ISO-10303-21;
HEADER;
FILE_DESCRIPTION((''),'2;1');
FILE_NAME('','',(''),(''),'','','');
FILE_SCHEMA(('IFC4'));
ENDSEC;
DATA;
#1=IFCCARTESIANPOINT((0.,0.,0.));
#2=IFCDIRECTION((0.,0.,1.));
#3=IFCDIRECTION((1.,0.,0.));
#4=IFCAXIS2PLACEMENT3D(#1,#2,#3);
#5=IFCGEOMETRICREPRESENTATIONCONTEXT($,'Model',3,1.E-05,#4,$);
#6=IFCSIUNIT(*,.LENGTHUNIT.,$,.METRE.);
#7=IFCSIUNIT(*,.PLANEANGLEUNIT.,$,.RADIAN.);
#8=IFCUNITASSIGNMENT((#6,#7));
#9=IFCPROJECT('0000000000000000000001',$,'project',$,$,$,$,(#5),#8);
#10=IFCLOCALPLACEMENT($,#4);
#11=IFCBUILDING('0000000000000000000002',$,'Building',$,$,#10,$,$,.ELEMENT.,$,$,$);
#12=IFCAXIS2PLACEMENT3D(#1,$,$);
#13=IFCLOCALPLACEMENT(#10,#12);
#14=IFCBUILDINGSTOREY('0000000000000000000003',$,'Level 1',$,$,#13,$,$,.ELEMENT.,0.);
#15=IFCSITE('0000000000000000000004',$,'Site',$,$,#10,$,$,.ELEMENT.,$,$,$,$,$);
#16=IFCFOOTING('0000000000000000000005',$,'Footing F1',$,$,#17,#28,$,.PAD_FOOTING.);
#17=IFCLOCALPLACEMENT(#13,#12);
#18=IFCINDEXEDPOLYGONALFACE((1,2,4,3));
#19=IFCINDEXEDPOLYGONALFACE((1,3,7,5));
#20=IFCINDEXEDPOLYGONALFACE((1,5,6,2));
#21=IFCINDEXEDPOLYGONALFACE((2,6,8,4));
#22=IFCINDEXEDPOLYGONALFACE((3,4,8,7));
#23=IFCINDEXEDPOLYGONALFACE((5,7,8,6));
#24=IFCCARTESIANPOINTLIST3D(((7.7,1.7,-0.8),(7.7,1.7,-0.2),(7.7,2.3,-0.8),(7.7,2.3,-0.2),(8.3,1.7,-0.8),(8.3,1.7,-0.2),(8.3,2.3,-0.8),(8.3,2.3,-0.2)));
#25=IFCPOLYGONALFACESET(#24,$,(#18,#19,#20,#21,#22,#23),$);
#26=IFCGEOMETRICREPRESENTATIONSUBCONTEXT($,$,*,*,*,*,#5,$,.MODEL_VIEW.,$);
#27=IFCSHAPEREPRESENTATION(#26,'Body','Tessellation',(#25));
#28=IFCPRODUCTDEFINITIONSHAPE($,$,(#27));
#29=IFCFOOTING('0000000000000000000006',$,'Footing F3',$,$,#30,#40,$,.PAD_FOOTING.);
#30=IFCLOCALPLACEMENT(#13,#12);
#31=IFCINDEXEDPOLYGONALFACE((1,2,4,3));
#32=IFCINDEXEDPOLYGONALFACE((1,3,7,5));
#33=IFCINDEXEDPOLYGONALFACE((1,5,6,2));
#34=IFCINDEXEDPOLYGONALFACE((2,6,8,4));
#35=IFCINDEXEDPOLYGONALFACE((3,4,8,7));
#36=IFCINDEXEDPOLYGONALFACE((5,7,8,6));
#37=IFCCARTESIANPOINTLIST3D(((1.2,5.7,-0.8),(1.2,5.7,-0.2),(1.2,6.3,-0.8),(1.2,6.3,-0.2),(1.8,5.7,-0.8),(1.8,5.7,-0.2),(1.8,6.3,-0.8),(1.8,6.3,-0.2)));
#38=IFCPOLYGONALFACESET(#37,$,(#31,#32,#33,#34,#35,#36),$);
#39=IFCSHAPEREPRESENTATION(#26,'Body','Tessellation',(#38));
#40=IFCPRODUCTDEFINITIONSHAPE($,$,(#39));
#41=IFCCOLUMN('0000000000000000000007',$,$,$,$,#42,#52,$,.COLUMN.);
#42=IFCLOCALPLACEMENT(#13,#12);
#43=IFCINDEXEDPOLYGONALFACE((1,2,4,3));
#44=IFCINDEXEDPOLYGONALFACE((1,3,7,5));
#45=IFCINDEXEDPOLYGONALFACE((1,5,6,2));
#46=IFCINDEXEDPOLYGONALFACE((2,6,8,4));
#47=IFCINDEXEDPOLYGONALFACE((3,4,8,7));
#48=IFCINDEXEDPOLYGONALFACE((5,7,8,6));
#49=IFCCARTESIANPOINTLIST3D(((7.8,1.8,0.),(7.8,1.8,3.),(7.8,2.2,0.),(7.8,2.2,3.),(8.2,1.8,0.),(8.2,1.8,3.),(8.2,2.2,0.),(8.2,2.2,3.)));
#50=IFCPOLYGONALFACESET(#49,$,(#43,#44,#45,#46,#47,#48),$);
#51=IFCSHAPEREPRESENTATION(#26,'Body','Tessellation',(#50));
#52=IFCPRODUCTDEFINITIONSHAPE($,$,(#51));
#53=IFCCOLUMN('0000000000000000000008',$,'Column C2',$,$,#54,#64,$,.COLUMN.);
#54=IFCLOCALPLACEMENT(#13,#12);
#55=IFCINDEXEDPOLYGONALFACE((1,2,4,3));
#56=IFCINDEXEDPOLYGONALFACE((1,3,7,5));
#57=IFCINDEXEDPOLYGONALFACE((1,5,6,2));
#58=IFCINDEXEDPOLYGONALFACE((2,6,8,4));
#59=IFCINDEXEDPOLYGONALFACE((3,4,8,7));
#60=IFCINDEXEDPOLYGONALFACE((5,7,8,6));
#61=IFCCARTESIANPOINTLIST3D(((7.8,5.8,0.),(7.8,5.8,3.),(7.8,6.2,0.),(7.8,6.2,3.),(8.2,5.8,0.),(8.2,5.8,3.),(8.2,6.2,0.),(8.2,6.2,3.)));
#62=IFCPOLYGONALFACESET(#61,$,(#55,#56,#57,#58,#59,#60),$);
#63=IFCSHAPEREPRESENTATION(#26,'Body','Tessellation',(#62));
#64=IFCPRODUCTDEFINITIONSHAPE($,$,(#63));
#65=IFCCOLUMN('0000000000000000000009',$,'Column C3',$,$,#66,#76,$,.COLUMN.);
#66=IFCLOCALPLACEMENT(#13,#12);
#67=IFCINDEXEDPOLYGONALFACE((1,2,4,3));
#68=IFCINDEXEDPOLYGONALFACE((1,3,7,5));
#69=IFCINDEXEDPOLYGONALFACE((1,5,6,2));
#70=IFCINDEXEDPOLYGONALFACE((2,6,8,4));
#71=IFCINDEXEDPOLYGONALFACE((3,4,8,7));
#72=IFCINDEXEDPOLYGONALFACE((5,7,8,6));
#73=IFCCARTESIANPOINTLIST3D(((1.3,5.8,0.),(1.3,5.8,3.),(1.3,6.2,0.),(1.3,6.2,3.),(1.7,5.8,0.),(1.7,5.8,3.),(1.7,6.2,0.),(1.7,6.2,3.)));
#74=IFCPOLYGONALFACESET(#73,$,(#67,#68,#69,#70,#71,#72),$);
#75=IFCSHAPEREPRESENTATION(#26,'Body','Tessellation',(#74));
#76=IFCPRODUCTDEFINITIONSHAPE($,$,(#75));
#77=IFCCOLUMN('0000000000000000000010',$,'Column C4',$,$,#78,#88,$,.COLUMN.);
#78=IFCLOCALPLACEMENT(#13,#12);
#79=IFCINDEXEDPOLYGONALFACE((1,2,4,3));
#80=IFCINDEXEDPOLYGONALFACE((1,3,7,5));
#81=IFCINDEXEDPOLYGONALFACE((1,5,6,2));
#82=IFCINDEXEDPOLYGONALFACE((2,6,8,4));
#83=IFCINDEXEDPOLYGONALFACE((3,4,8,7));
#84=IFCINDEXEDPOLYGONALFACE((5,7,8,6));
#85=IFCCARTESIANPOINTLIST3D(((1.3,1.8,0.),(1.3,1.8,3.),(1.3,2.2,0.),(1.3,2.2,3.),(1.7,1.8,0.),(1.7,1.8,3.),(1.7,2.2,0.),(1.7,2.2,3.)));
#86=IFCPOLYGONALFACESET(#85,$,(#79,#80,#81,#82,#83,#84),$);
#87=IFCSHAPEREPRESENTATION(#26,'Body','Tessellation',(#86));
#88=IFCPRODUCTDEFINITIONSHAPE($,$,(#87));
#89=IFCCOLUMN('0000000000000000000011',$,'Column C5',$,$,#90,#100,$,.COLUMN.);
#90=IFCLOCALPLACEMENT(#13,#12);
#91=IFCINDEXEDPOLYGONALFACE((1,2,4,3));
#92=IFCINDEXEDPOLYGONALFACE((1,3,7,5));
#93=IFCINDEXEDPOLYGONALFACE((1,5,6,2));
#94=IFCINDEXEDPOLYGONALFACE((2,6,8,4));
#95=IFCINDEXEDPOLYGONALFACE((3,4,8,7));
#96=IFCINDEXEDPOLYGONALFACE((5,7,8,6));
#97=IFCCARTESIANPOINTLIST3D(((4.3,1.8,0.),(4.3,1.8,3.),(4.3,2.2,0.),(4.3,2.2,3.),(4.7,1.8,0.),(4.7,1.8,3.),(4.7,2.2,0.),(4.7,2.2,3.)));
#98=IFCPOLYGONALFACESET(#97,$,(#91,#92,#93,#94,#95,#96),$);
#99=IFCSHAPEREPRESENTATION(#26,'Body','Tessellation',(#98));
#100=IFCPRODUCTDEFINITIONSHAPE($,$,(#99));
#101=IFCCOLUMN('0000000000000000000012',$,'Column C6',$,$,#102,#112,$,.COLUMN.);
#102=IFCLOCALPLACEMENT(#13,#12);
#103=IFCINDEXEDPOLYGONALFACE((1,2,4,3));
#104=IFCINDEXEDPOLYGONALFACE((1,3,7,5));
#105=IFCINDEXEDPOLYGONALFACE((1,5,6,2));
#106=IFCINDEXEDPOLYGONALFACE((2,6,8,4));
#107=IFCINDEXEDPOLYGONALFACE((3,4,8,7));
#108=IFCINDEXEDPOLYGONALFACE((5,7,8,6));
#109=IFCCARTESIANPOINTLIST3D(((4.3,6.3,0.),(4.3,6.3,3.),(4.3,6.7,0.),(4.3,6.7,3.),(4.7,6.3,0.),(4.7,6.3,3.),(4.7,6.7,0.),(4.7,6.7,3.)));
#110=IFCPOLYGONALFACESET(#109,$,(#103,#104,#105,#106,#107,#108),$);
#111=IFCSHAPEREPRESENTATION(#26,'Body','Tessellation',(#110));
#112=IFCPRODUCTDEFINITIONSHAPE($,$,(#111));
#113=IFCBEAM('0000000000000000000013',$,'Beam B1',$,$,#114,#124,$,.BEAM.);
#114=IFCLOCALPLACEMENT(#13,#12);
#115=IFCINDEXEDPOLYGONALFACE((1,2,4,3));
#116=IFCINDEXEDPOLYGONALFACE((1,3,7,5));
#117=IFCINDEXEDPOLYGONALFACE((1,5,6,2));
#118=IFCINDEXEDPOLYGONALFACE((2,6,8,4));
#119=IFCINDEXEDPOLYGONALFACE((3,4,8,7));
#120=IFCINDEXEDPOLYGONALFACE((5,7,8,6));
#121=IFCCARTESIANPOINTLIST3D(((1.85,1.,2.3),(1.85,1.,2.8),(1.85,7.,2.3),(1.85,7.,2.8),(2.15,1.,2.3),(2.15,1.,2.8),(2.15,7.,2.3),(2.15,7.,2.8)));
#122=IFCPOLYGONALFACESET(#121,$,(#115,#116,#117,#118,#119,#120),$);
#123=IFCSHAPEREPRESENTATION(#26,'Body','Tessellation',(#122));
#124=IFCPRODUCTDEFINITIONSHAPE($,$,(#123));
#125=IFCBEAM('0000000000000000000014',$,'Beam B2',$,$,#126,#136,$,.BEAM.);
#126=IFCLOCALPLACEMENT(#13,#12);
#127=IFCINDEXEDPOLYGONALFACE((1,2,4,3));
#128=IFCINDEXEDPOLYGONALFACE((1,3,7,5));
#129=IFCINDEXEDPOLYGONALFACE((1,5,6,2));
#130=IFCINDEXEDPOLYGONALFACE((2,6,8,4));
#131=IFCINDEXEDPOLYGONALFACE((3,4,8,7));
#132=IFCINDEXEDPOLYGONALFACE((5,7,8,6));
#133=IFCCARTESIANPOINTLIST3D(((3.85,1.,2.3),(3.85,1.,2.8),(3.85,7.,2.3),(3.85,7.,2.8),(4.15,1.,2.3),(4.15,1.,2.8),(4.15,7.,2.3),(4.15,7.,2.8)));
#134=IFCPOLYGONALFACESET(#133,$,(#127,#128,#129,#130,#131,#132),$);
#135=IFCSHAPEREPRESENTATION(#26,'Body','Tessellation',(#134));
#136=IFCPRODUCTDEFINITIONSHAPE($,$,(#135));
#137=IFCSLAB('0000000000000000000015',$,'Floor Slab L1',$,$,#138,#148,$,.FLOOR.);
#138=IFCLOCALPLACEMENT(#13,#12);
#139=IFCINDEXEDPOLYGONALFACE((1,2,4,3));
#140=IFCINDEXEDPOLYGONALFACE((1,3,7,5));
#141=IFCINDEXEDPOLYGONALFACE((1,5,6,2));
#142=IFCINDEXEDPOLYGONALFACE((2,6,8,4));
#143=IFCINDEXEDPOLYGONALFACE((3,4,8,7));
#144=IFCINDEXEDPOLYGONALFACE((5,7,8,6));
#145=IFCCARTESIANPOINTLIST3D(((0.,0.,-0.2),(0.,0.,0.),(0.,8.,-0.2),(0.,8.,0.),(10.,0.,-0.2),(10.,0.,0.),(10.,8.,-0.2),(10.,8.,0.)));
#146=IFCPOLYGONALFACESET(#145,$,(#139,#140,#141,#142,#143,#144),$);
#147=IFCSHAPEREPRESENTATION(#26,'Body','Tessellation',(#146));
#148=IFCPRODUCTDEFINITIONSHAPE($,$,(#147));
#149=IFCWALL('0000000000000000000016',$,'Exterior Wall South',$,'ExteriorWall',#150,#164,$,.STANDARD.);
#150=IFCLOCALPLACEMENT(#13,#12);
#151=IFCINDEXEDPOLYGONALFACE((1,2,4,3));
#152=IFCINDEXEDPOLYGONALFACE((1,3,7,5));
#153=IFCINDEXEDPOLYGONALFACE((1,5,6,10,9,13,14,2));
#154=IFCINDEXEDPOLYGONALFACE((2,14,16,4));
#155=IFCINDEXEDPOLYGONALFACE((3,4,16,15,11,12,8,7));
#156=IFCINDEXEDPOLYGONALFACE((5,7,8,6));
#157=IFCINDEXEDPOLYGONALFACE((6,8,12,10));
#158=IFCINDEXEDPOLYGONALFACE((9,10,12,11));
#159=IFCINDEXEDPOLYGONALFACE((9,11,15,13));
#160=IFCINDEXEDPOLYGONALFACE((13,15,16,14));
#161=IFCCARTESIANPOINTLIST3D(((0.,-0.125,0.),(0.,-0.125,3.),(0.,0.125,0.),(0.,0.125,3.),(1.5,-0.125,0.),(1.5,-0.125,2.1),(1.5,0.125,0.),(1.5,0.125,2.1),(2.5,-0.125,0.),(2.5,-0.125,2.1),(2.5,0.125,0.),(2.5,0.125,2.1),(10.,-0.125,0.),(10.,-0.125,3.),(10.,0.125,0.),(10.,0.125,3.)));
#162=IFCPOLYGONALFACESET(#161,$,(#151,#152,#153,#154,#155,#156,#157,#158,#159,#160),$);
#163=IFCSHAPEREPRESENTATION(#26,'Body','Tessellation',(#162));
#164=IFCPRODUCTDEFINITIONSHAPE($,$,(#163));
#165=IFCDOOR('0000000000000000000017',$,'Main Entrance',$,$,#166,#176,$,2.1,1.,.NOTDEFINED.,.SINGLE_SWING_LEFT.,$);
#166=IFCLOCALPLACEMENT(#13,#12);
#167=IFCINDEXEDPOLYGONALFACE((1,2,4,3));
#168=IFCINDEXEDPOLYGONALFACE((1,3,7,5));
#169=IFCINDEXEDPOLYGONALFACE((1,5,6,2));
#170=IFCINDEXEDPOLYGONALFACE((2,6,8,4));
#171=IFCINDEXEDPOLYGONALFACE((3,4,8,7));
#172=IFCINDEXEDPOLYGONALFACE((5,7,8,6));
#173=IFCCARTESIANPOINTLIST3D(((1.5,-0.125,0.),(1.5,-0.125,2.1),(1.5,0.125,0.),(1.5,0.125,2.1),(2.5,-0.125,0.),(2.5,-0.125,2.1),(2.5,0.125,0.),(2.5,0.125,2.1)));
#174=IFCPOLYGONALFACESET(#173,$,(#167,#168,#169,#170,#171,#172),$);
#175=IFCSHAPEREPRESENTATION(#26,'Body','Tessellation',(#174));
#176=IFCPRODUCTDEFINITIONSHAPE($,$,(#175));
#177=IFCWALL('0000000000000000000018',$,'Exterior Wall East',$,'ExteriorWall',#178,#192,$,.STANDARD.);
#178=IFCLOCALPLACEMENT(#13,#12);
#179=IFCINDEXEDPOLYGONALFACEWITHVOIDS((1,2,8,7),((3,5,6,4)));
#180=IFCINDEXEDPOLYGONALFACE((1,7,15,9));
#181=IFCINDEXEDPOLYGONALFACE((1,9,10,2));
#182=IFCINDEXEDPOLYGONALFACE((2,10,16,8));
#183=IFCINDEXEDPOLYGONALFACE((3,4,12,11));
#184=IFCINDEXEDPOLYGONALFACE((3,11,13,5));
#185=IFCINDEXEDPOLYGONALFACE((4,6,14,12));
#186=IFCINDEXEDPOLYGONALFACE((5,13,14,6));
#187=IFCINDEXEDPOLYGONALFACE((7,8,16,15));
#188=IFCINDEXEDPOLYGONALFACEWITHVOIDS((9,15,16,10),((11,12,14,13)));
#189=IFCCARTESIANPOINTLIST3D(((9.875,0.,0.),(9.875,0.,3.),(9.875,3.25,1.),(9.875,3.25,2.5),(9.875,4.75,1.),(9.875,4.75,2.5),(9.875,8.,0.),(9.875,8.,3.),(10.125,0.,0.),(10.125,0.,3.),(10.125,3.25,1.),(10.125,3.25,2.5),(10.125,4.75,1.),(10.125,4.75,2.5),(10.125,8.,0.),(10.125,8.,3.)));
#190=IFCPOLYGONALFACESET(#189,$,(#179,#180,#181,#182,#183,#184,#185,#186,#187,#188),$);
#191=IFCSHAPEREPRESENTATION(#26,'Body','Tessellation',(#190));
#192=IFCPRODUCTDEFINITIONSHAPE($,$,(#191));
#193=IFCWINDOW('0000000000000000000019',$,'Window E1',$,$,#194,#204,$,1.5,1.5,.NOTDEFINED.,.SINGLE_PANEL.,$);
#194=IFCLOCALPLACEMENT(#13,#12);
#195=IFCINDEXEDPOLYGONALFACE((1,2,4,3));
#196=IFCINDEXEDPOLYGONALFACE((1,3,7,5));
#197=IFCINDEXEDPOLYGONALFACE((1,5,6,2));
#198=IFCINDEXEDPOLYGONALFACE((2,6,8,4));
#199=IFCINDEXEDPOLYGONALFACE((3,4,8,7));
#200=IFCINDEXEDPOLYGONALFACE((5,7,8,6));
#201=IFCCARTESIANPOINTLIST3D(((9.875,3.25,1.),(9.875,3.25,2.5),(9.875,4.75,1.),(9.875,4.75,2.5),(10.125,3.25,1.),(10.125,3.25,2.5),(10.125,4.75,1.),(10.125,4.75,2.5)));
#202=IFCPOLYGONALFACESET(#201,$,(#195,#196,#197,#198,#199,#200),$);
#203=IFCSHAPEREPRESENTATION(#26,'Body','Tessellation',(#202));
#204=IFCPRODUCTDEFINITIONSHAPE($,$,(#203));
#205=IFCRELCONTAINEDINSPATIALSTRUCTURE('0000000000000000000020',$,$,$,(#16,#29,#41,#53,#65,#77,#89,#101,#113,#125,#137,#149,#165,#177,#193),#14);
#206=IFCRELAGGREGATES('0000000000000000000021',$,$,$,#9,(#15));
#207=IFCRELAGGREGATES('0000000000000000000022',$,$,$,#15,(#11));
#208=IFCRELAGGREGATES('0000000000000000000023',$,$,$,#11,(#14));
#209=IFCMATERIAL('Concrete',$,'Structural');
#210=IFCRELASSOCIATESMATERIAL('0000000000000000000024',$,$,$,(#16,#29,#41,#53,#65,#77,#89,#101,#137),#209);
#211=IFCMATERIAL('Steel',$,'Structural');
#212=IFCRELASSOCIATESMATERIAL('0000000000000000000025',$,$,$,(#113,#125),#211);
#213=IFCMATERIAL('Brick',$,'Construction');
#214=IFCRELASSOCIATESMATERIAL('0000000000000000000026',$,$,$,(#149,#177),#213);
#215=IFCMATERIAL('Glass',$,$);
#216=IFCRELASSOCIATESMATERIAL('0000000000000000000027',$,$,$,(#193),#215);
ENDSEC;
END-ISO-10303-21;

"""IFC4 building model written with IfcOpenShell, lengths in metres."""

from ifc_helpers import new_model, si_unit, frame, frame_2d, origin, origin_with_axes, origin_2d, place, context, subcontext, project, spatial, rectangle, extrude, material, element, fill, save


model = new_model("IFC4")

# Units and contexts
model_context = context("Model", 3, precision=1e-05, world=origin_with_axes())
sub_context = subcontext(model_context, None, None, "MODEL_VIEW")
ifc_project = project(units=[si_unit("LENGTHUNIT", "METRE"), si_unit("PLANEANGLEUNIT", "RADIAN")], contexts=[model_context])

# Site, building, storey
placement = place(None, origin_with_axes())
site = spatial("IfcSite", under=ifc_project, at=placement, Name="Site", CompositionType="ELEMENT")
building = spatial("IfcBuilding", under=site, at=placement, Name="Building", CompositionType="ELEMENT")
storey_placement = place(placement, origin())
storey = spatial("IfcBuildingStorey", under=building, at=storey_placement, Name="Level 1", CompositionType="ELEMENT", Elevation=0.0)

# Footings
ifc_material_1 = material(Name="Concrete", Category="Structural")
for number, where, name in (
    (1, (8.0, 2.0, -0.8), "Footing F1"),
    (2, (1.5, 6.0, -0.8), "Footing F3"),
):
    element("IfcFooting", number, at=place(placement, frame(where)), inside=storey, material=ifc_material_1, Name=name, PredefinedType="PAD_FOOTING", context=sub_context, shape_type="SweptSolid", body=[
        extrude(rectangle(XDim=0.6, YDim=0.6, at=origin_2d()), origin(), (0.0, 0.0, 1.0), 0.6),
    ])

# Columns
column_placement = place(storey_placement, frame((8.0, 2.0, 0.0)))
element("IfcColumn", 3, at=column_placement, inside=storey, material=ifc_material_1, PredefinedType="COLUMN", context=sub_context, shape_type="SweptSolid", body=[
    extrude(rectangle(XDim=0.4, YDim=0.4, at=origin_2d()), origin(), (0.0, 0.0, 1.0), 3.0),
])
for number, where, name in (
    (4, (8.0, 6.0, 0.0), "Column C2"),
    (5, (1.5, 6.0, 0.0), "Column C3"),
    (6, (1.5, 2.0, 0.0), "Column C4"),
    (7, (4.5, 2.0, 0.0), "Column C5"),
    (8, (4.5, 6.5, 0.0), "Column C6"),
):
    element("IfcColumn", number, at=place(storey_placement, frame(where)), inside=storey, material=ifc_material_1, Name=name, PredefinedType="COLUMN", context=sub_context, shape_type="SweptSolid", body=[
        extrude(rectangle(XDim=0.4, YDim=0.4, at=origin_2d()), origin(), (0.0, 0.0, 1.0), 3.0),
    ])

# Beams
ifc_material_2 = material(Name="Steel", Category="Structural")
for number, where, z_axis, x_axis, name in (
    (9, (2.0, 1.0, 2.55), (0.0, 1.0, 0.0), (-1.0, 0.0, 0.0), "Beam B1"),
    (10, (4.0, 1.0, 2.55), (0.0, 1.0, 0.0), (-1.0, 0.0, 0.0), "Beam B2"),
):
    element("IfcBeam", number, at=place(storey_placement, frame(where, z_axis=z_axis, x_axis=x_axis)), inside=storey, material=ifc_material_2, Name=name, PredefinedType="BEAM", context=sub_context, shape_type="SweptSolid", body=[
        extrude(rectangle(XDim=0.3, YDim=0.5, at=origin_2d()), origin(), (0.0, 0.0, 1.0), 6.0),
    ])

# Slab
slab_placement = place(storey_placement, frame((0.0, 0.0, -0.2)))
element("IfcSlab", 11, at=slab_placement, inside=storey, material=ifc_material_1, Name="Floor Slab L1", PredefinedType="FLOOR", context=sub_context, shape_type="SweptSolid", body=[
    extrude(rectangle(XDim=10.0, YDim=8.0, at=frame_2d((5.0, 4.0))), origin(), (0.0, 0.0, 1.0), 0.2),
])

# Wall, opening, door
ifc_material_3 = material(Name="Brick", Category="Construction")
wall_1_placement = place(storey_placement, frame((0.0, 0.0, 0.0), x_axis=(1.0, 0.0, 0.0)))
wall_1 = element("IfcWall", 12, at=wall_1_placement, inside=storey, material=ifc_material_3, Name="Exterior Wall South", ObjectType="ExteriorWall", PredefinedType="STANDARD", context=sub_context, shape_type="SweptSolid", body=[
    extrude(rectangle(XDim=10.0, YDim=0.25, at=frame_2d((5.0, 0.0))), origin(), (0.0, 0.0, 1.0), 3.0),
])
opening_1_placement = place(wall_1_placement, frame((2.0, 0.175, 0.0), z_axis=(0.0, -1.0, 0.0), x_axis=(1.0, 0.0, 0.0)))
opening_1 = element("IfcOpeningElement", 13, at=opening_1_placement, cuts=wall_1, PredefinedType="OPENING", context=sub_context, shape_type="SweptSolid", body=[
    extrude(rectangle(XDim=1.0, YDim=2.1, at=frame_2d((0.0, 1.05))), origin(), (0.0, 0.0, 1.0), 0.35),
])
door_1_placement = place(wall_1_placement, frame((2.0, 0.125, 0.0), z_axis=(0.0, -1.0, 0.0), x_axis=(1.0, 0.0, 0.0)))
door_1 = element("IfcDoor", 14, at=door_1_placement, inside=storey, Name="Main Entrance", OperationType="SINGLE_SWING_LEFT", OverallHeight=2.1, OverallWidth=1.0, PredefinedType="NOTDEFINED", context=sub_context, shape_type="SweptSolid", body=[
    extrude(rectangle(XDim=1.0, YDim=2.1, at=frame_2d((0.0, 1.05))), origin(), (0.0, 0.0, 1.0), 0.25),
])
fill(opening_1, door_1)

# Wall, opening, window
wall_2_placement = place(storey_placement, frame((10.0, 0.0, 0.0), x_axis=(0.0, 1.0, 0.0)))
wall_2 = element("IfcWall", 15, at=wall_2_placement, inside=storey, material=ifc_material_3, Name="Exterior Wall East", ObjectType="ExteriorWall", PredefinedType="STANDARD", context=sub_context, shape_type="SweptSolid", body=[
    extrude(rectangle(XDim=8.0, YDim=0.25, at=frame_2d((4.0, 0.0))), origin(), (0.0, 0.0, 1.0), 3.0),
])
opening_2_placement = place(wall_2_placement, frame((4.0, 0.175, 1.0), z_axis=(0.0, -1.0, 0.0), x_axis=(1.0, 0.0, 0.0)))
opening_2 = element("IfcOpeningElement", 16, at=opening_2_placement, cuts=wall_2, PredefinedType="OPENING", context=sub_context, shape_type="SweptSolid", body=[
    extrude(rectangle(XDim=1.5, YDim=1.5, at=frame_2d((0.0, 0.75))), origin(), (0.0, 0.0, 1.0), 0.35),
])
ifc_material_4 = material(Name="Glass")
window_1_placement = place(wall_2_placement, frame((4.0, 0.125, 1.0), z_axis=(0.0, -1.0, 0.0), x_axis=(1.0, 0.0, 0.0)))
window_1 = element("IfcWindow", 17, at=window_1_placement, inside=storey, material=ifc_material_4, Name="Window E1", OverallHeight=1.5, OverallWidth=1.5, PartitioningType="SINGLE_PANEL", PredefinedType="NOTDEFINED", context=sub_context, shape_type="SweptSolid", body=[
    extrude(rectangle(XDim=1.5, YDim=1.5, at=frame_2d((0.0, 0.75))), origin(), (0.0, 0.0, 1.0), 0.25),
])
fill(opening_2, window_1)

save(model, "model.ifc")
